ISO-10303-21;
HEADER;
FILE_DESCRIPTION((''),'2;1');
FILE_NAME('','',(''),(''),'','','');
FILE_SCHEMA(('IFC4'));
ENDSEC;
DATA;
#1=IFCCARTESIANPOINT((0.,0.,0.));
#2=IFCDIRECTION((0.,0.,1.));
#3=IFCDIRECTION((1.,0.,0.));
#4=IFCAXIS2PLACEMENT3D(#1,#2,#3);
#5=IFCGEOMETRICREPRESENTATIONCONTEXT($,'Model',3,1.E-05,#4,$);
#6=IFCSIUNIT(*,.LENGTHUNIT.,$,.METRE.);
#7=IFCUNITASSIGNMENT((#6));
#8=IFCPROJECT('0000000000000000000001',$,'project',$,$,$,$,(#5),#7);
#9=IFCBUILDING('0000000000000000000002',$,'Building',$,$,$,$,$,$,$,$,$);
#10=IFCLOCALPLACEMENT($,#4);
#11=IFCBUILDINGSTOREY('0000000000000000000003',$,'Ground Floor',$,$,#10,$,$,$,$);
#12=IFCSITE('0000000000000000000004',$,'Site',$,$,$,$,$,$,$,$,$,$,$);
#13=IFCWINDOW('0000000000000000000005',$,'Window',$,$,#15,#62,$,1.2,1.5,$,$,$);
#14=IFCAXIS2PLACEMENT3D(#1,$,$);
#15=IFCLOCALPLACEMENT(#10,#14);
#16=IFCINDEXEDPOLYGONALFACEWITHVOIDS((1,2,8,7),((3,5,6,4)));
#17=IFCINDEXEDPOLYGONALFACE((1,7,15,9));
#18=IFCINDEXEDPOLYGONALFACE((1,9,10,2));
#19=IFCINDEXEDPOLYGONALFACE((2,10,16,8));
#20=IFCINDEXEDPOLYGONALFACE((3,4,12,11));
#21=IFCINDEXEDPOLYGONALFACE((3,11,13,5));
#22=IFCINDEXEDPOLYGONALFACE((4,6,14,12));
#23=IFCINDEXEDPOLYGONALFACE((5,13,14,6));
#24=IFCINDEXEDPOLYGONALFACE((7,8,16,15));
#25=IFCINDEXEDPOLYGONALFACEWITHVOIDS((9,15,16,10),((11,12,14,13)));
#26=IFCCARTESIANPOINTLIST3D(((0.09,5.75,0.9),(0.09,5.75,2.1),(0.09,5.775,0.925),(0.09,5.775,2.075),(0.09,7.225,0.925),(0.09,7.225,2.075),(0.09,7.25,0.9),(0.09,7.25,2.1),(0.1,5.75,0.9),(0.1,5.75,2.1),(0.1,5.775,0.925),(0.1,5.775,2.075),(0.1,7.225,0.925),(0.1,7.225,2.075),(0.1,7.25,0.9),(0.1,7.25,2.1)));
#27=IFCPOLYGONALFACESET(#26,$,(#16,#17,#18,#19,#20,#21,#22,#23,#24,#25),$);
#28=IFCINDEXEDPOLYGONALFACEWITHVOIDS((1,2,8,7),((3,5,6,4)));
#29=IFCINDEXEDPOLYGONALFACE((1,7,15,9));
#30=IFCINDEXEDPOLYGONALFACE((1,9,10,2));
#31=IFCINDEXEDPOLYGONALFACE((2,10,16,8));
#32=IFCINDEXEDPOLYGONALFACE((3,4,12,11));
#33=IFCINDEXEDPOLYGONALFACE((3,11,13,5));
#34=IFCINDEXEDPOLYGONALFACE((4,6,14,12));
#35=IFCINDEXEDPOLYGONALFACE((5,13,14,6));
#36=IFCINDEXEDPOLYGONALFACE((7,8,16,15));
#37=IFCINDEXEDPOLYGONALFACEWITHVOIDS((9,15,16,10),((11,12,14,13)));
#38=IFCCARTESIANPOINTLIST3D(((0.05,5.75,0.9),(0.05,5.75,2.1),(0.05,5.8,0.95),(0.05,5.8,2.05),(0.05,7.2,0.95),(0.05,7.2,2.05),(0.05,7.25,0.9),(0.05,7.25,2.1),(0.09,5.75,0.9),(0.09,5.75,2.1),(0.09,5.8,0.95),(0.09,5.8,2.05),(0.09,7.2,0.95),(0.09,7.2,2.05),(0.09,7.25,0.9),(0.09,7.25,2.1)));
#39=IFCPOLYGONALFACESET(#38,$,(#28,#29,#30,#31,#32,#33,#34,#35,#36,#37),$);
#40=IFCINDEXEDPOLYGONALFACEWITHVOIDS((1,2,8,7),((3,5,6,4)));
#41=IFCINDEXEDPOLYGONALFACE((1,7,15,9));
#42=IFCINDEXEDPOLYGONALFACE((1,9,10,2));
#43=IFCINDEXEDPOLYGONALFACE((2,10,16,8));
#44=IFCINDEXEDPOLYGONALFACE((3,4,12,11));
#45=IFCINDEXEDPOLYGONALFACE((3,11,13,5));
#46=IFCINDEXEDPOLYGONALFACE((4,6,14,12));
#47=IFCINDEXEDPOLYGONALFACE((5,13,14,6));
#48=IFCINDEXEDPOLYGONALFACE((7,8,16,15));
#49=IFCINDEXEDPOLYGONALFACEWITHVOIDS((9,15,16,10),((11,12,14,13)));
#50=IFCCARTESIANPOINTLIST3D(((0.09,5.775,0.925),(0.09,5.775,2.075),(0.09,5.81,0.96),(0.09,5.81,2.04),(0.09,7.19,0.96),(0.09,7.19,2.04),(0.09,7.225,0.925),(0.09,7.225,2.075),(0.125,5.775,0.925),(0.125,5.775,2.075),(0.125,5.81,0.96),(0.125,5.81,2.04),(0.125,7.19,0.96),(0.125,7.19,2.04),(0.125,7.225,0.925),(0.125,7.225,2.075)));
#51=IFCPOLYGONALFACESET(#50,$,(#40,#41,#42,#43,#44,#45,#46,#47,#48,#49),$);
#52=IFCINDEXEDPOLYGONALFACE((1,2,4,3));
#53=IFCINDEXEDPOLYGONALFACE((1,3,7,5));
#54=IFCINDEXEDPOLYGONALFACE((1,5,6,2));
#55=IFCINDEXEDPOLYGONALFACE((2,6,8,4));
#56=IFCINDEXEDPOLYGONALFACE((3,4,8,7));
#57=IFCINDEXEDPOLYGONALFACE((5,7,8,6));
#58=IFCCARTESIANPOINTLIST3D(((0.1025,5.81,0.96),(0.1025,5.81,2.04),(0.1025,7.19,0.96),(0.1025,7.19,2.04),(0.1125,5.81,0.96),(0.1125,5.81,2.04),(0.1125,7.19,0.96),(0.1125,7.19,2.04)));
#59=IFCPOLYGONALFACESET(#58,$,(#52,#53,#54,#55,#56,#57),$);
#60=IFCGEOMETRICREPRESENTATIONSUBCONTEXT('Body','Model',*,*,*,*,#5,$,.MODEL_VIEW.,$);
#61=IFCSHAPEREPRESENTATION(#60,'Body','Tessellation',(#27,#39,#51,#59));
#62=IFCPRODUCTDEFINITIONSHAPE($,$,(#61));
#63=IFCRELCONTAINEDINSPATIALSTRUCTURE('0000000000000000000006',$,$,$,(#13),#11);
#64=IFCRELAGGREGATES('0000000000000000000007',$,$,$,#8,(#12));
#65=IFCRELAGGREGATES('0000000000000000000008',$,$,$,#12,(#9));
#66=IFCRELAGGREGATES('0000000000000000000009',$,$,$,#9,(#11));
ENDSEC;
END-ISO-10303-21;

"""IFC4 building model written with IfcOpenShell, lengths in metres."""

from ifc_helpers import new_model, si_unit, frame, origin_with_axes, place, context, subcontext, project, spatial, line, indexed_curve, outline, extrude, element, save


model = new_model("IFC4")

# Units and contexts
model_context = context("Model", 3, precision=1e-05, world=origin_with_axes())
body_context = subcontext(model_context, "Body", "Model", "MODEL_VIEW")
ifc_project = project(units=[si_unit("LENGTHUNIT", "METRE")], contexts=[model_context])

# Site, building, storey
site = spatial("IfcSite", under=ifc_project, Name="Site")
building = spatial("IfcBuilding", under=site, Name="Building")
storey_placement = place(None, origin_with_axes())
storey = spatial("IfcBuildingStorey", under=building, at=storey_placement, Name="Ground Floor")

# Window
window_1_placement = place(storey_placement, frame((0.0, 7.25, 0.9), z_axis=(0.0, 0.0, 1.0), x_axis=(0.0, -1.0, 0.0)))
element("IfcWindow", 1, at=window_1_placement, inside=storey, Name="Window", OverallHeight=1.2, OverallWidth=1.5, context=body_context, shape_type="SweptSolid", body=[
    extrude(outline(indexed_curve([(0.0, 0.0), (1.5, 0.0), (1.5, 1.2), (0.0, 1.2)], segments=[line(1, 2, 3, 4, 1)]), holes=[indexed_curve([(0.025, 0.025), (1.475, 0.025), (1.475, 1.175), (0.025, 1.175)], segments=[line(1, 2, 3, 4, 1)])]), frame((0.0, 0.09, 0.0), z_axis=(0.0, -1.0, 0.0), x_axis=(1.0, 0.0, 0.0)), (0.0, 0.0, -1.0), 0.01),
    extrude(outline(indexed_curve([(0.0, 0.0), (1.5, 0.0), (1.5, 1.2), (0.0, 1.2)], segments=[line(1, 2, 3, 4, 1)]), holes=[indexed_curve([(0.05, 0.05), (1.45, 0.05), (1.45, 1.15), (0.05, 1.15)], segments=[line(1, 2, 3, 4, 1)])]), frame((0.0, 0.05, 0.0), z_axis=(0.0, -1.0, 0.0), x_axis=(1.0, 0.0, 0.0)), (0.0, 0.0, -1.0), 0.04),
    extrude(outline(indexed_curve([(0.0, 0.0), (1.45, 0.0), (1.45, 1.15), (0.0, 1.15)], segments=[line(1, 2, 3, 4, 1)]), holes=[indexed_curve([(0.035, 0.035), (1.415, 0.035), (1.415, 1.115), (0.035, 1.115)], segments=[line(1, 2, 3, 4, 1)])]), frame((0.025, 0.09, 0.025), z_axis=(0.0, -1.0, 0.0), x_axis=(1.0, 0.0, 0.0)), (0.0, 0.0, -1.0), 0.035),
    extrude(outline(indexed_curve([(0.035, 0.035), (1.415, 0.035), (1.415, 1.115), (0.035, 1.115)], segments=[line(1, 2, 3, 4, 1)])), frame((0.025, 0.1025, 0.025), z_axis=(0.0, -1.0, 0.0), x_axis=(1.0, 0.0, 0.0)), (0.0, 0.0, -1.0), 0.01),
])

save(model, "model.ifc")
